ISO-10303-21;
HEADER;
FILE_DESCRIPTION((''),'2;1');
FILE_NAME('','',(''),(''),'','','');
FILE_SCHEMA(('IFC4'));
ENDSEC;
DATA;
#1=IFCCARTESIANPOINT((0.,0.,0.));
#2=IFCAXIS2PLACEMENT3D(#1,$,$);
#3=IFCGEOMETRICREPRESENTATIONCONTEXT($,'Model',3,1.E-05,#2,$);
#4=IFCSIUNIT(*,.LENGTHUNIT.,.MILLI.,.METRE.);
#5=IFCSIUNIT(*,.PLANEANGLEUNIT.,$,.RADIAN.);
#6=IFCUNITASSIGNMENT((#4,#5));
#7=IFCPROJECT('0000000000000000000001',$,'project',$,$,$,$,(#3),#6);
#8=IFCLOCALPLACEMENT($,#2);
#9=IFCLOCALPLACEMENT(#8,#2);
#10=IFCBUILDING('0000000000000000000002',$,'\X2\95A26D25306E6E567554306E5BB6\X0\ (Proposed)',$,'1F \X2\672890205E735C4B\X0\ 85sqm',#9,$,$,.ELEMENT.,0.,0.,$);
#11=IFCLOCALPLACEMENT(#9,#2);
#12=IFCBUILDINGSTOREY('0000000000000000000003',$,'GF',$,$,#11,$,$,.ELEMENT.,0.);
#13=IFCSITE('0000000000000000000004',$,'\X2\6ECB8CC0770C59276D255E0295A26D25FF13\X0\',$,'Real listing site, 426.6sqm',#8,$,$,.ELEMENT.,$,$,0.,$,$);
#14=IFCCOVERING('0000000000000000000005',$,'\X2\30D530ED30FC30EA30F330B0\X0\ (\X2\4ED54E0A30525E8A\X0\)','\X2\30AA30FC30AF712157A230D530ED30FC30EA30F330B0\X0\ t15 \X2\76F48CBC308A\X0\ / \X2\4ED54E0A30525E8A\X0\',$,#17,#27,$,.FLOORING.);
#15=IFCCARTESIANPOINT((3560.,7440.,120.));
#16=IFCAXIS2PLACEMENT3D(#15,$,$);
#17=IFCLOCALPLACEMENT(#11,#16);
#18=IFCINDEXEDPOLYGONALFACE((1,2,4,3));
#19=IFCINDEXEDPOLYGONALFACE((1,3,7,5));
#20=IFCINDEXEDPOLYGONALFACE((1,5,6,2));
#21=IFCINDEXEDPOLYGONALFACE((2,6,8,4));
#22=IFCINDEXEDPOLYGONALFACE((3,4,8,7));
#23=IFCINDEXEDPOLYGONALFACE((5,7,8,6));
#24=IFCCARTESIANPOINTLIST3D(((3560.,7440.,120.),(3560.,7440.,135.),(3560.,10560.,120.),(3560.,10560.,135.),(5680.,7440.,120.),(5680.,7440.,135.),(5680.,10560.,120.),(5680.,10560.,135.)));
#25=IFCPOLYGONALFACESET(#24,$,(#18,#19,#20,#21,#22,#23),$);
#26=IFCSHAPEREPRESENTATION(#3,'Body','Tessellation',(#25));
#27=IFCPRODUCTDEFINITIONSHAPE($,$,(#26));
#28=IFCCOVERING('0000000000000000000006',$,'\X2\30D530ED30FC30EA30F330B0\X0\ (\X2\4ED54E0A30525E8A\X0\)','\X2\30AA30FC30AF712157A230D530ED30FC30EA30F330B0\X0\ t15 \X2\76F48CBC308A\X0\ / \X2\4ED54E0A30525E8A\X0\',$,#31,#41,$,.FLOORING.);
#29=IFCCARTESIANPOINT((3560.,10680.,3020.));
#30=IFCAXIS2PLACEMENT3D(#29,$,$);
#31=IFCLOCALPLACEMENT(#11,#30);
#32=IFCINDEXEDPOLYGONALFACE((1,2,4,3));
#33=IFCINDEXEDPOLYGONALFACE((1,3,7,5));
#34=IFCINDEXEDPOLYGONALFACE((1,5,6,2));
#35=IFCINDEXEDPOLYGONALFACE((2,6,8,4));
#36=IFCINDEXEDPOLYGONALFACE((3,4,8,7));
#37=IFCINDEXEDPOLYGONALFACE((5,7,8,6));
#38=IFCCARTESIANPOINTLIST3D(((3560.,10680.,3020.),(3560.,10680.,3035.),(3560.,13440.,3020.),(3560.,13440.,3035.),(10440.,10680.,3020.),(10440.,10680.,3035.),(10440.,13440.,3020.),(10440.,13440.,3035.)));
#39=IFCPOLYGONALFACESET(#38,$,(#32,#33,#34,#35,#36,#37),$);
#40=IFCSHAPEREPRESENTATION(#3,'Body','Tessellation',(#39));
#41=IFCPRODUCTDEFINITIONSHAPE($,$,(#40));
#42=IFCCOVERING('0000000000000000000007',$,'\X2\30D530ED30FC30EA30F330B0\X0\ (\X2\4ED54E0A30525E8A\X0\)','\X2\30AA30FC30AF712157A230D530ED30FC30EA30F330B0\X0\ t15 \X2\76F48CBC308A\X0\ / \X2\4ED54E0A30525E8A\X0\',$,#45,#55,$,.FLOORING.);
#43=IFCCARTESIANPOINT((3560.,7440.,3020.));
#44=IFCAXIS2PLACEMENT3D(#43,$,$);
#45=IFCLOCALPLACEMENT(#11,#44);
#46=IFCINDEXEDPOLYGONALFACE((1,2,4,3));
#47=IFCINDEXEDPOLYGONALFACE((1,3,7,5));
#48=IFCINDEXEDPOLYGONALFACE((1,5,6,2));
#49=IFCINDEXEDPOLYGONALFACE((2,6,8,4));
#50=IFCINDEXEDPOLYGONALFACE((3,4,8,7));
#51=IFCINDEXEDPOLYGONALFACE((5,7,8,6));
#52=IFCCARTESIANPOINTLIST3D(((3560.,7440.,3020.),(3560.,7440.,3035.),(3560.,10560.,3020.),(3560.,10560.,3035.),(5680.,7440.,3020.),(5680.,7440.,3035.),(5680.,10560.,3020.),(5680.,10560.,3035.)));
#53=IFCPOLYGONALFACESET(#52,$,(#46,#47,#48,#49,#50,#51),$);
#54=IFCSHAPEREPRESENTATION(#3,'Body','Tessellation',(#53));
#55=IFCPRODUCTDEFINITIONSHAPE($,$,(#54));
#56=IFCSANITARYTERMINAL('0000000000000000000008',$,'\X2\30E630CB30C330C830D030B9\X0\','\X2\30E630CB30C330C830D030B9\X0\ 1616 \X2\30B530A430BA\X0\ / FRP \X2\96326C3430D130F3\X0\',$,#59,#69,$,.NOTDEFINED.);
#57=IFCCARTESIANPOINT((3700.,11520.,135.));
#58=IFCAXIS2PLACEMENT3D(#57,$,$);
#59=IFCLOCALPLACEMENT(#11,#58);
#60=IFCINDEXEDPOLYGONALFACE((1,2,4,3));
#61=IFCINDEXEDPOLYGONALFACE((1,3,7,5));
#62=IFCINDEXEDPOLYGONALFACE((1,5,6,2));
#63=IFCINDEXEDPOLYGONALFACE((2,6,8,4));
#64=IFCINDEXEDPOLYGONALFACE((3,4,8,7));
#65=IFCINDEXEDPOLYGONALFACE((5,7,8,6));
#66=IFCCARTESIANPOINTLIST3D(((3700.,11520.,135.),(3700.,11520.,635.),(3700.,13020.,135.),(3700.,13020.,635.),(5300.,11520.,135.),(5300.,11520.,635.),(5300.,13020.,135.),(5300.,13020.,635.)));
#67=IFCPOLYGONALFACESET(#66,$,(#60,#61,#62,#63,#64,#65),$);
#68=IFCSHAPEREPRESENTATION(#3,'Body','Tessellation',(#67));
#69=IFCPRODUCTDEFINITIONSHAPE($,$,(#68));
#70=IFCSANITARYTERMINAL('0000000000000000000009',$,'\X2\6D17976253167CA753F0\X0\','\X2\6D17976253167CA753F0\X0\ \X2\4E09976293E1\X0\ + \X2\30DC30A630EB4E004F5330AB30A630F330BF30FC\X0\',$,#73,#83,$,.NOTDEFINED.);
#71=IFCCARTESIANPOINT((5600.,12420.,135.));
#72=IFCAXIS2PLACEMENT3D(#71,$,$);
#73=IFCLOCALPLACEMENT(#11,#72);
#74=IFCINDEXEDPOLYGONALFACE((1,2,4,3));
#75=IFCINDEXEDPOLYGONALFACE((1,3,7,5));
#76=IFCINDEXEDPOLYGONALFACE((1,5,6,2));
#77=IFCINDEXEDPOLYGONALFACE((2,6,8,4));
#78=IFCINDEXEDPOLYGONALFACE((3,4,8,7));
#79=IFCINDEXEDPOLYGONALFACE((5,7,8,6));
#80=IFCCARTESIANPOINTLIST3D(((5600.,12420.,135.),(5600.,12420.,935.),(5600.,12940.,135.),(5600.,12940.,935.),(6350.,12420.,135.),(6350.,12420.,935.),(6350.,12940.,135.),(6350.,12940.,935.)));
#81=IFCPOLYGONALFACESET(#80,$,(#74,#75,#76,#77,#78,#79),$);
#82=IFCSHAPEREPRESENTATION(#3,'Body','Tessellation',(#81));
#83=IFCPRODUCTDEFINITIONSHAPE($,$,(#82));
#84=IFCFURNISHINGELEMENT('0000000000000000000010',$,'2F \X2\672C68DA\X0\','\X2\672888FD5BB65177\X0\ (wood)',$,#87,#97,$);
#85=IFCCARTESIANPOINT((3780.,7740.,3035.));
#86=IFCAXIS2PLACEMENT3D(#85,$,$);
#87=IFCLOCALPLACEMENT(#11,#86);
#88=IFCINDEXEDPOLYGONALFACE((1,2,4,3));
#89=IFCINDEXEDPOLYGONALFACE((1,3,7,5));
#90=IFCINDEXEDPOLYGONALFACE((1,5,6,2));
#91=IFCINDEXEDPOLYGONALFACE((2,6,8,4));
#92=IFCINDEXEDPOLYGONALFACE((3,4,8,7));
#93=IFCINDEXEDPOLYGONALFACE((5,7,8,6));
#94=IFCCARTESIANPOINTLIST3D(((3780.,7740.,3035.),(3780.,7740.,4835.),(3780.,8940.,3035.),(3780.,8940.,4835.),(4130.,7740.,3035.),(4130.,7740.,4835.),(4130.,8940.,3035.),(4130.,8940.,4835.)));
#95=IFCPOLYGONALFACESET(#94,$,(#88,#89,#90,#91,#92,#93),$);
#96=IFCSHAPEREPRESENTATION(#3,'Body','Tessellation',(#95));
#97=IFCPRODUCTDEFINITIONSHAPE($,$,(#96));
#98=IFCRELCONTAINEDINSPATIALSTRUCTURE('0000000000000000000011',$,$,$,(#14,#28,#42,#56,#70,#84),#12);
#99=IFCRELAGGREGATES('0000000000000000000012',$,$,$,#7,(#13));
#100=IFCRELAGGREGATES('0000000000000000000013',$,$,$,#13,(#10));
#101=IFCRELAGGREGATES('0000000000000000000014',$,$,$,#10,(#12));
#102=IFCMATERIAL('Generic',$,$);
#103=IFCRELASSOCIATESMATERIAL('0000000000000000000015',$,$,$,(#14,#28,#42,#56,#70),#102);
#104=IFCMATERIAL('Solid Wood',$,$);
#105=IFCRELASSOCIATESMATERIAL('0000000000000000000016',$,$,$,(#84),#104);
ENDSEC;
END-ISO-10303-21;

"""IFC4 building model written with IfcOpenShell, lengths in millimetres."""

from ifc_helpers import new_model, si_unit, frame, frame_2d, origin, place, context, project, spatial, rectangle, extrude, material, element, save


model = new_model("IFC4")

# Units and contexts
model_context = context("Model", 3, precision=1e-05, world=origin())
ifc_project = project(units=[si_unit("LENGTHUNIT", "METRE", prefix="MILLI"), si_unit("PLANEANGLEUNIT", "RADIAN")], contexts=[model_context])

# Site, building, storey
site_placement = place(None, origin())
site = spatial("IfcSite", under=ifc_project, at=site_placement, Name="滋賀県大津市関津３", ObjectType="Real listing site, 426.6sqm", CompositionType="ELEMENT", RefElevation=0.0)
building_placement = place(site_placement, origin())
building = spatial("IfcBuilding", under=site, at=building_placement, Name="関津の湖畔の家 (Proposed)", ObjectType="1F 木造平屋 85sqm", CompositionType="ELEMENT", ElevationOfRefHeight=0.0, ElevationOfTerrain=0.0)
storey_placement = place(building_placement, origin())
storey = spatial("IfcBuildingStorey", under=building, at=storey_placement, Name="GF", CompositionType="ELEMENT", Elevation=0.0)

# Shared definitions
ifc_material_1 = material(Name="Solid Wood")

# Coverings
ifc_material_2 = material(Name="Generic")
covering_1_placement = place(storey_placement, frame((3560.0, 7440.0, 120.0)))
element("IfcCovering", 1, at=covering_1_placement, inside=storey, material=ifc_material_2, Name="フローリング (仕上げ床)", Description="オーク無垢フローリング t15 直貼り / 仕上げ床", PredefinedType="FLOORING", context=model_context, shape_type="SweptSolid", body=[
    extrude(rectangle(XDim=2120.0, YDim=3120.0, at=frame_2d((1060.0, 1560.0))), frame((3560.0, 7440.0, 120.0)), (0.0, 0.0, 1.0), 15.0),
])
covering_2_placement = place(storey_placement, frame((3560.0, 10680.0, 3020.0)))
element("IfcCovering", 2, at=covering_2_placement, inside=storey, material=ifc_material_2, Name="フローリング (仕上げ床)", Description="オーク無垢フローリング t15 直貼り / 仕上げ床", PredefinedType="FLOORING", context=model_context, shape_type="SweptSolid", body=[
    extrude(rectangle(XDim=6880.0, YDim=2760.0, at=frame_2d((3440.0, 1380.0))), frame((3560.0, 10680.0, 3020.0)), (0.0, 0.0, 1.0), 15.0),
])
covering_3_placement = place(storey_placement, frame((3560.0, 7440.0, 3020.0)))
element("IfcCovering", 3, at=covering_3_placement, inside=storey, material=ifc_material_2, Name="フローリング (仕上げ床)", Description="オーク無垢フローリング t15 直貼り / 仕上げ床", PredefinedType="FLOORING", context=model_context, shape_type="SweptSolid", body=[
    extrude(rectangle(XDim=2120.0, YDim=3120.0, at=frame_2d((1060.0, 1560.0))), frame((3560.0, 7440.0, 3020.0)), (0.0, 0.0, 1.0), 15.0),
])

# Sanitary terminals
sanitary_terminal_1_placement = place(storey_placement, frame((3700.0, 11520.0, 135.0)))
element("IfcSanitaryTerminal", 4, at=sanitary_terminal_1_placement, inside=storey, material=ifc_material_2, Name="ユニットバス", Description="ユニットバス 1616 サイズ / FRP 防水パン", PredefinedType="NOTDEFINED", context=model_context, shape_type="SweptSolid", body=[
    extrude(rectangle(XDim=1600.0, YDim=1500.0, at=frame_2d((800.0, 750.0))), frame((3700.0, 11520.0, 135.0)), (0.0, 0.0, 1.0), 500.0),
])
sanitary_terminal_2_placement = place(storey_placement, frame((5600.0, 12420.0, 135.0)))
element("IfcSanitaryTerminal", 5, at=sanitary_terminal_2_placement, inside=storey, material=ifc_material_2, Name="洗面化粧台", Description="洗面化粧台 三面鏡 + ボウル一体カウンター", PredefinedType="NOTDEFINED", context=model_context, shape_type="SweptSolid", body=[
    extrude(rectangle(XDim=750.0, YDim=520.0, at=frame_2d((375.0, 260.0))), frame((5600.0, 12420.0, 135.0)), (0.0, 0.0, 1.0), 800.0),
])

# Furnishing element
furnishing_placement = place(storey_placement, frame((3780.0, 7740.0, 3035.0)))
element("IfcFurnishingElement", 6, at=furnishing_placement, inside=storey, material=ifc_material_1, Name="2F 本棚", Description="木製家具 (wood)", context=model_context, shape_type="SweptSolid", body=[
    extrude(rectangle(XDim=350.0, YDim=1200.0, at=frame_2d((175.0, 600.0))), frame((3780.0, 7740.0, 3035.0)), (0.0, 0.0, 1.0), 1800.0),
])

save(model, "model.ifc")
